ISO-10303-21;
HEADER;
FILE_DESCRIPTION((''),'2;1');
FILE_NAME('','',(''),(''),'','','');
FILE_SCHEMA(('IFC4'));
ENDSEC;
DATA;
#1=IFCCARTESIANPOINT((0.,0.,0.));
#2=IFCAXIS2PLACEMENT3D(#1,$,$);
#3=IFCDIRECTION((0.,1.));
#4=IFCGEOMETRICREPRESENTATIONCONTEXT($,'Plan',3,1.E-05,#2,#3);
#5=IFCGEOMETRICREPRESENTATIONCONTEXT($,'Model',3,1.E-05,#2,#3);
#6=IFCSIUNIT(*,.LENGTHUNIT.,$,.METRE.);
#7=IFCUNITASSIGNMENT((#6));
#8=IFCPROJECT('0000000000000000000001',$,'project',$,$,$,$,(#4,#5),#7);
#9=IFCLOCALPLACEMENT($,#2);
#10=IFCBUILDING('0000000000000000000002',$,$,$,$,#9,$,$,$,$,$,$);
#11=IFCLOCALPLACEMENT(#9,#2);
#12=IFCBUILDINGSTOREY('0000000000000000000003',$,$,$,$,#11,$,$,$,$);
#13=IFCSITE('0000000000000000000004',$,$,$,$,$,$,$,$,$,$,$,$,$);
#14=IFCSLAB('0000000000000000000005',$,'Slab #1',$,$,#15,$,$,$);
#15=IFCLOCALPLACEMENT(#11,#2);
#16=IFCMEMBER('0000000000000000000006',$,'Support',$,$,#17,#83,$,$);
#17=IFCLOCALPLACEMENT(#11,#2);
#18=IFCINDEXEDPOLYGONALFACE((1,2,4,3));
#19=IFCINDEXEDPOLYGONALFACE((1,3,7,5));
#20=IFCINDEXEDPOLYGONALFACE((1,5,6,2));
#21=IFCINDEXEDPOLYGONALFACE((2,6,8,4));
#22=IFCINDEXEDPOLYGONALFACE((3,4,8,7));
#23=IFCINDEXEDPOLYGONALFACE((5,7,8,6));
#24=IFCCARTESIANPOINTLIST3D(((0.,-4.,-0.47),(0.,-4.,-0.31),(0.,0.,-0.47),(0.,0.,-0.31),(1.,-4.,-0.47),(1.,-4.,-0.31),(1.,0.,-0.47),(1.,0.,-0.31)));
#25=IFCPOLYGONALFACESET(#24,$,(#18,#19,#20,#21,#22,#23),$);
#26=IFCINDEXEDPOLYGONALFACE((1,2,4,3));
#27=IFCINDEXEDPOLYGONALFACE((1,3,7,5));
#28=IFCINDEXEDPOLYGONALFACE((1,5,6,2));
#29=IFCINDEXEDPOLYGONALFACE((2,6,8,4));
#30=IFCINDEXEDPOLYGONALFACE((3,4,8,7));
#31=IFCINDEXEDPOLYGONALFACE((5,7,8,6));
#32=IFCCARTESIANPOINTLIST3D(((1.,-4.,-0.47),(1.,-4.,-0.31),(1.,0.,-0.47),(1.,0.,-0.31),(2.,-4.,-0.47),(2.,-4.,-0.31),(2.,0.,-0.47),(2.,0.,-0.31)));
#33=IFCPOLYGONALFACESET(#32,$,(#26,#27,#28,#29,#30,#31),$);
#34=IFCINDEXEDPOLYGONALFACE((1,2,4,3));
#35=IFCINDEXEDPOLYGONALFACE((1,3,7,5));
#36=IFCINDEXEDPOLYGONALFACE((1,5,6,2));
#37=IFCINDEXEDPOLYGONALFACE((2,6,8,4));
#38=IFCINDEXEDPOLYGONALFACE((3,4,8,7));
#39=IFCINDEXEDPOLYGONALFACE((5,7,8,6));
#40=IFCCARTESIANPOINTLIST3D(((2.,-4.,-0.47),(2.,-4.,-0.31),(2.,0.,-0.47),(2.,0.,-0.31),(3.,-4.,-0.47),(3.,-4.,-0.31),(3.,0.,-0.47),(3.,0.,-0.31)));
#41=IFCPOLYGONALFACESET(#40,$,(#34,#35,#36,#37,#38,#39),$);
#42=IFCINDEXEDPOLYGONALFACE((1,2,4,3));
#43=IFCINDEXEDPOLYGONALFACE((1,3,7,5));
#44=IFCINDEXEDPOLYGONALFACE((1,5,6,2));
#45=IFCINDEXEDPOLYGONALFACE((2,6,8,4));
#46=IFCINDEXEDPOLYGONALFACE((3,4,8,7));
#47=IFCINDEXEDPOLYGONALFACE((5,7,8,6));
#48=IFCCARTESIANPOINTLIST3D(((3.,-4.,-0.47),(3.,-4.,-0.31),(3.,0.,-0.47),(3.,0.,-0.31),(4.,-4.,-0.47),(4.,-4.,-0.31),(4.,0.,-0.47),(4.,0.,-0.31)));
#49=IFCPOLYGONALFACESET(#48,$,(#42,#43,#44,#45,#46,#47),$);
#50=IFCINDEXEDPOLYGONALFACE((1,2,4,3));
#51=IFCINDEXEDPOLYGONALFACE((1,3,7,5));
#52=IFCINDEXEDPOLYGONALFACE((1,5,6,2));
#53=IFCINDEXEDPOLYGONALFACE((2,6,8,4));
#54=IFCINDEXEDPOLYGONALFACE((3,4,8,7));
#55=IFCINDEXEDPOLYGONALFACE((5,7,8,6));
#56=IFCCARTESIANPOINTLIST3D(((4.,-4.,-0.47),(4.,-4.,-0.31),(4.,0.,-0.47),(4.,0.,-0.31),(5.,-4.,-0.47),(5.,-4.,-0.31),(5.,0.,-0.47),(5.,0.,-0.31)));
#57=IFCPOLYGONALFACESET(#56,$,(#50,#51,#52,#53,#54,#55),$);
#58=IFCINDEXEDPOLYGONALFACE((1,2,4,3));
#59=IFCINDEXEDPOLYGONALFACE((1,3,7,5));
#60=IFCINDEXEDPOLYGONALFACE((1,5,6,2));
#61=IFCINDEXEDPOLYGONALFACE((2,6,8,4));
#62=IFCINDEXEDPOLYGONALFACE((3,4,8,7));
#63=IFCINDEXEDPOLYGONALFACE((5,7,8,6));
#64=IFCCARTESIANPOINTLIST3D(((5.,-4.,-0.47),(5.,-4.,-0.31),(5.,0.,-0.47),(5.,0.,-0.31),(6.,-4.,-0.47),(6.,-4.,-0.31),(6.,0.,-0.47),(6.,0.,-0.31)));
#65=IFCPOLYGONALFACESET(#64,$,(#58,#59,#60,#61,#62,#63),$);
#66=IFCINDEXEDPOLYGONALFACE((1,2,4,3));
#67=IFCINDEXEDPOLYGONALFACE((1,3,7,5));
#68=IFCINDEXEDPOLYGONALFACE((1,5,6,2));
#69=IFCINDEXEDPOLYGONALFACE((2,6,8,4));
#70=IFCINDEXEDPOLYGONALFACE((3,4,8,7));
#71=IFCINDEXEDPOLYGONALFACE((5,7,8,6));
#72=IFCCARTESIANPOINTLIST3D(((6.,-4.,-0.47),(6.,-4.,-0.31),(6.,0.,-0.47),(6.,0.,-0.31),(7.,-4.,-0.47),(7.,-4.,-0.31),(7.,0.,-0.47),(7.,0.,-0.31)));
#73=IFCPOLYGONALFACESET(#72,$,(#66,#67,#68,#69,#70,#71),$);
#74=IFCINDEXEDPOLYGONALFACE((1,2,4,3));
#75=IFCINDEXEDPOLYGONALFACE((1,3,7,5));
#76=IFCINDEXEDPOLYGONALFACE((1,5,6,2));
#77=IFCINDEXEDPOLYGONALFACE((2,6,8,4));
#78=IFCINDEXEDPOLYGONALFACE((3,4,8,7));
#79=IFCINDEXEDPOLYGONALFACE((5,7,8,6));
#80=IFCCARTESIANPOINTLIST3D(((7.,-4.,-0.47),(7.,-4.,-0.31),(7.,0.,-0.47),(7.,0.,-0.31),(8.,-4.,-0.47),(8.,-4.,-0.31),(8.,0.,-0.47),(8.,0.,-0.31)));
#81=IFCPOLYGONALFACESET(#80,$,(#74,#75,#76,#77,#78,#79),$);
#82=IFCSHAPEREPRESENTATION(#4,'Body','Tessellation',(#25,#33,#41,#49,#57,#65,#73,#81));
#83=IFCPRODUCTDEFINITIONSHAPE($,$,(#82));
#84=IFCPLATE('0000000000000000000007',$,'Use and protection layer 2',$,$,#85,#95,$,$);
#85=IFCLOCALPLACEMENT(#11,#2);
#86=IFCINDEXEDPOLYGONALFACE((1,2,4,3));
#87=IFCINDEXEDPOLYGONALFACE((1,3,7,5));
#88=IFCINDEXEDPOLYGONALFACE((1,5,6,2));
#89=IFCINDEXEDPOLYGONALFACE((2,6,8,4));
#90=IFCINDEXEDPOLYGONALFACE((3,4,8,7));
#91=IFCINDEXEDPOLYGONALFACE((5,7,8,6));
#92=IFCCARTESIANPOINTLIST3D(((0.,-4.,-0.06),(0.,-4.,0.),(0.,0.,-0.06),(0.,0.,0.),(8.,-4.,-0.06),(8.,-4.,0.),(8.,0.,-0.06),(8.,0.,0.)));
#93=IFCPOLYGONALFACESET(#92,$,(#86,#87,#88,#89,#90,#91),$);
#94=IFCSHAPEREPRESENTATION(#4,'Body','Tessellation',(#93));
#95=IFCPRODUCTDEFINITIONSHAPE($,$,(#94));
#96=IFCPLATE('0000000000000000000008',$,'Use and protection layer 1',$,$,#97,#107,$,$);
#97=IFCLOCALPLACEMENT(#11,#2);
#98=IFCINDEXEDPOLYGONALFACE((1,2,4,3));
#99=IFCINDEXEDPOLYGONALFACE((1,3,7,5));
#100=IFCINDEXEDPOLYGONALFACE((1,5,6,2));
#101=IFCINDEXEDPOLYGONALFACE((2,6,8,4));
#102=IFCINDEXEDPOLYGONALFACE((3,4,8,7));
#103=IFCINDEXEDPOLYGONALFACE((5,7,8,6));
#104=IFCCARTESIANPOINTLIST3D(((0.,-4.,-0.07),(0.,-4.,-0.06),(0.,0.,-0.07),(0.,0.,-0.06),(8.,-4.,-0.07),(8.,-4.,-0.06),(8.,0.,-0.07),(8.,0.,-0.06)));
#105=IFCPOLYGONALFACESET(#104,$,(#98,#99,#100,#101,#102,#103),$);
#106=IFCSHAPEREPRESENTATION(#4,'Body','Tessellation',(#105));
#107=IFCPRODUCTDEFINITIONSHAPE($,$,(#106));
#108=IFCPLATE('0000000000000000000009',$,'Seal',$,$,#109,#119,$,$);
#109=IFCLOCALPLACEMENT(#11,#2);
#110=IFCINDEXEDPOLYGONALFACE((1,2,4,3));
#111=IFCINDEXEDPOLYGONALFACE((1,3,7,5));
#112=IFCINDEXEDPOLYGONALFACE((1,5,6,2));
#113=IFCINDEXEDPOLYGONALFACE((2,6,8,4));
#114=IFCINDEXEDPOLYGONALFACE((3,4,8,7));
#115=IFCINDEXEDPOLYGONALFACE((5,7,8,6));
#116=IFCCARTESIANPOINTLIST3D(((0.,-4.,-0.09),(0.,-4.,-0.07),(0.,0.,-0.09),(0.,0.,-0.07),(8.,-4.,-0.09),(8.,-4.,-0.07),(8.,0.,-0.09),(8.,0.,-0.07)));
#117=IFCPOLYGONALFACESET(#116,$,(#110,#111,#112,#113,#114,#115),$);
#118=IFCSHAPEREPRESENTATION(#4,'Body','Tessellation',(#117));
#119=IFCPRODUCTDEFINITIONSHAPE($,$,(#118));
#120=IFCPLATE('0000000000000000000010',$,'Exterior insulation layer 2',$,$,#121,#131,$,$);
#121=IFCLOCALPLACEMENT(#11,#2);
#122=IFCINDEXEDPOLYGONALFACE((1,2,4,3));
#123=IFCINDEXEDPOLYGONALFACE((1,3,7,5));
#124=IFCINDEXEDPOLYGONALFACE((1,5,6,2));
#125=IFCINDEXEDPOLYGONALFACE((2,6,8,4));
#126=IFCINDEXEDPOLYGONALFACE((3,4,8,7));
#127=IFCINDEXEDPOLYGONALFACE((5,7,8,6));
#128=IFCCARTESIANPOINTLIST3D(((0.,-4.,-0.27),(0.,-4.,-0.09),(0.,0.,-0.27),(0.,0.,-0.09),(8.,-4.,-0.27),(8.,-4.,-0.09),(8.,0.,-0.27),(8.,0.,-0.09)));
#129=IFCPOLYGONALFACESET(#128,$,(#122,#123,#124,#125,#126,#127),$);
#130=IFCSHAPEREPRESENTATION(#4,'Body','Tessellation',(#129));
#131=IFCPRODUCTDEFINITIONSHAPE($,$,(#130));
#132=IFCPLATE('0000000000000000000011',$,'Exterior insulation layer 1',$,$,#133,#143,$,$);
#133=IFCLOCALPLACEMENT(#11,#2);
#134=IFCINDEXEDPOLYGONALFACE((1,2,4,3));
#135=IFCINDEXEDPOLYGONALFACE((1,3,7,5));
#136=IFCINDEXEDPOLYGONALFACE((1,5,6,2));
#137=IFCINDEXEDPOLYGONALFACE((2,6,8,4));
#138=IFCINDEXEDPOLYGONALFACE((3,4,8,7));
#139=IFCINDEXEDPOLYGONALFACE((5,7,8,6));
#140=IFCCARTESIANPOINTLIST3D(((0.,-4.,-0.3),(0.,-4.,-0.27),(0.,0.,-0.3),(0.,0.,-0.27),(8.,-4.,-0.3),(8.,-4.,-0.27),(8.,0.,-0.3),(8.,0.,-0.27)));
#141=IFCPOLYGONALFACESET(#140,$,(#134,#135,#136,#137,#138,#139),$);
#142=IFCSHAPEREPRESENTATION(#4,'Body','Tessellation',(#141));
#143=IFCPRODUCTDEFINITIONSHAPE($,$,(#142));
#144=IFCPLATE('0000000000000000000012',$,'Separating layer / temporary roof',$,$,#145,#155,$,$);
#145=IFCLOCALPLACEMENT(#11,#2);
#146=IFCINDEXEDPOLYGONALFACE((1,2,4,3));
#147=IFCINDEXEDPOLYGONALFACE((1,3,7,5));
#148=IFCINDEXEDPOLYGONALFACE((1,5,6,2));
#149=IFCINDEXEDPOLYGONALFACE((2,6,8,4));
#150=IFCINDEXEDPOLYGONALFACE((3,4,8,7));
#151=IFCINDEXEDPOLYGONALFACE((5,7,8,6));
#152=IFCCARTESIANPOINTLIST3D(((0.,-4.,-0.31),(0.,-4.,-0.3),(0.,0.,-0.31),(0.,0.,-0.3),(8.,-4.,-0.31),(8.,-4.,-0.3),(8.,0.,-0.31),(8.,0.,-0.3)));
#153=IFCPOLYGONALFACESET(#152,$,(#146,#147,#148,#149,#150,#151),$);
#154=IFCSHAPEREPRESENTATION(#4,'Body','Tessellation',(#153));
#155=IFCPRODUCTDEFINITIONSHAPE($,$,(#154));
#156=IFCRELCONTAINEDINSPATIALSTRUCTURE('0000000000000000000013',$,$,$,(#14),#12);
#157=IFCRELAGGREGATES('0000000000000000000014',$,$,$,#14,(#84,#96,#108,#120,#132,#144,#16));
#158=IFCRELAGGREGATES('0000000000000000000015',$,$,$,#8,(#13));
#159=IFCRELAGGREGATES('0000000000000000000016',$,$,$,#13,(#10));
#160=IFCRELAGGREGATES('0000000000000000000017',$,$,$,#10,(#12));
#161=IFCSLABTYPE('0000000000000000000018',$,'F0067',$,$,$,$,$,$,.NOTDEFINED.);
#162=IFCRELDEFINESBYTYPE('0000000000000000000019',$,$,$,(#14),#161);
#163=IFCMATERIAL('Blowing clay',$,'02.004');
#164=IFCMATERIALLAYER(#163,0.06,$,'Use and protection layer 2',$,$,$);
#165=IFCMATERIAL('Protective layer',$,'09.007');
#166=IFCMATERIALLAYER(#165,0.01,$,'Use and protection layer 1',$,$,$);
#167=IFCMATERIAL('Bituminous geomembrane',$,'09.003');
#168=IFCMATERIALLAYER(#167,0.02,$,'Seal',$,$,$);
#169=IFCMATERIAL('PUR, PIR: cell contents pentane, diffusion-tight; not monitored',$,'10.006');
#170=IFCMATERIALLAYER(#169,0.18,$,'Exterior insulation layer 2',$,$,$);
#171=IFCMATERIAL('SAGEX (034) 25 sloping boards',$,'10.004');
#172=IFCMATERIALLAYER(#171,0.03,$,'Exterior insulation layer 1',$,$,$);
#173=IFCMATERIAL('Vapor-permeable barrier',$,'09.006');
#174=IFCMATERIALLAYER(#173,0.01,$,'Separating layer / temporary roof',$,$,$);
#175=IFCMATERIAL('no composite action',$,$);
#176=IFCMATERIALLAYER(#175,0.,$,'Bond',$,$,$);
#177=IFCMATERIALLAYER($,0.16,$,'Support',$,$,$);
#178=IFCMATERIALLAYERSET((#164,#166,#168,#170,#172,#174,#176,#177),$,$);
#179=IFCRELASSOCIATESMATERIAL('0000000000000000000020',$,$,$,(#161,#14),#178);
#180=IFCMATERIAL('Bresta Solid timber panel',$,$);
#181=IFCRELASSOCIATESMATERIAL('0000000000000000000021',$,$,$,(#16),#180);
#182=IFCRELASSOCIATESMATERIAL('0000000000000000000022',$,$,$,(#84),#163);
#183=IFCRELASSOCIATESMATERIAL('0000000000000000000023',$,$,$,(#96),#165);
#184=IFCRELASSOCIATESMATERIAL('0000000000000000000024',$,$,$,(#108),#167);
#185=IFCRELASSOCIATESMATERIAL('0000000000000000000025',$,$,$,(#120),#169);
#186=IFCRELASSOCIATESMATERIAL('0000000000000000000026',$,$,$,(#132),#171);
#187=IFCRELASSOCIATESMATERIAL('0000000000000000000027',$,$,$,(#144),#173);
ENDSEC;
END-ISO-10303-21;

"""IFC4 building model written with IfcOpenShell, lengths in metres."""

from ifc_helpers import new_model, si_unit, direction, frame, frame_2d, origin, origin_with_axes, place, context, project, spatial, rectangle, extrude, material, layer, layer_set, type_object, element, aggregate, save


model = new_model("IFC4")

# Units and contexts
plan_context = context("Plan", 3, precision=1e-05, world=origin(), true_north=direction((0.0, 1.0)))
model_context = context("Model", 3, precision=1e-05, world=origin(), true_north=direction((0.0, 1.0)))
ifc_project = project(units=[si_unit("LENGTHUNIT", "METRE")], contexts=[plan_context, model_context])

# Site, building, storey
site = spatial("IfcSite", under=ifc_project)
building_placement = place(None, origin())
building = spatial("IfcBuilding", under=site, at=building_placement)
storey_placement = place(building_placement, origin())
storey = spatial("IfcBuildingStorey", under=building, at=storey_placement)

# Slab, member, plates
ifc_material_1 = material(Name="Blowing clay", Category="02.004")
ifc_layer_1 = layer(ifc_material_1, 0.06, Name="Use and protection layer 2")
ifc_material_2 = material(Name="Protective layer", Category="09.007")
ifc_layer_2 = layer(ifc_material_2, 0.01, Name="Use and protection layer 1")
ifc_material_3 = material(Name="Bituminous geomembrane", Category="09.003")
ifc_layer_3 = layer(ifc_material_3, 0.02, Name="Seal")
ifc_material_4 = material(Name="PUR, PIR: cell contents pentane, diffusion-tight; not monitored", Category="10.006")
ifc_layer_4 = layer(ifc_material_4, 0.18, Name="Exterior insulation layer 2")
ifc_material_5 = material(Name="SAGEX (034) 25 sloping boards", Category="10.004")
ifc_layer_5 = layer(ifc_material_5, 0.03, Name="Exterior insulation layer 1")
ifc_material_6 = material(Name="Vapor-permeable barrier", Category="09.006")
ifc_layer_6 = layer(ifc_material_6, 0.01, Name="Separating layer / temporary roof")
ifc_material_7 = material(Name="no composite action")
ifc_layer_7 = layer(ifc_material_7, 0.0, Name="Bond")
ifc_layer_8 = layer(None, 0.16, Name="Support")
ifc_layer_set = layer_set([ifc_layer_1, ifc_layer_2, ifc_layer_3, ifc_layer_4, ifc_layer_5, ifc_layer_6, ifc_layer_7, ifc_layer_8])
slab_type = type_object("IfcSlabType", Name="F0067", PredefinedType="NOTDEFINED", material=ifc_layer_set)
slab_placement = place(None, frame((0.0, 0.0, 0.0), z_axis=(0.0, 0.0, -1.0), x_axis=(1.0, 0.0, 0.0)))
slab = element("IfcSlab", 1, at=slab_placement, inside=storey, type_object=slab_type, material=ifc_layer_set, Name="Slab #1")
ifc_material_8 = material(Name="Bresta Solid timber panel")
member_placement = place(slab_placement, origin())
member = element("IfcMember", 2, at=member_placement, material=ifc_material_8, Name="Support", context=plan_context, shape_type="SweptSolid", body=[
    extrude(rectangle(XDim=1.0, YDim=0.16, at=frame_2d((0.5, 0.08), x_axis=(1.0, 0.0))), frame((0.0, 4.0, 0.31), z_axis=(0.0, -1.0, 0.0), x_axis=(1.0, 0.0, 0.0)), (0.0, 0.0, 1.0), 4.0),
    extrude(rectangle(XDim=1.0, YDim=0.16, at=frame_2d((0.5, 0.08), x_axis=(1.0, 0.0))), frame((1.0, 4.0, 0.31), z_axis=(0.0, -1.0, 0.0), x_axis=(1.0, 0.0, 0.0)), (0.0, 0.0, 1.0), 4.0),
    extrude(rectangle(XDim=1.0, YDim=0.16, at=frame_2d((0.5, 0.08), x_axis=(1.0, 0.0))), frame((2.0, 4.0, 0.31), z_axis=(0.0, -1.0, 0.0), x_axis=(1.0, 0.0, 0.0)), (0.0, 0.0, 1.0), 4.0),
    extrude(rectangle(XDim=1.0, YDim=0.16, at=frame_2d((0.5, 0.08), x_axis=(1.0, 0.0))), frame((3.0, 4.0, 0.31), z_axis=(0.0, -1.0, 0.0), x_axis=(1.0, 0.0, 0.0)), (0.0, 0.0, 1.0), 4.0),
    extrude(rectangle(XDim=1.0, YDim=0.16, at=frame_2d((0.5, 0.08), x_axis=(1.0, 0.0))), frame((4.0, 4.0, 0.31), z_axis=(0.0, -1.0, 0.0), x_axis=(1.0, 0.0, 0.0)), (0.0, 0.0, 1.0), 4.0),
    extrude(rectangle(XDim=1.0, YDim=0.16, at=frame_2d((0.5, 0.08), x_axis=(1.0, 0.0))), frame((5.0, 4.0, 0.31), z_axis=(0.0, -1.0, 0.0), x_axis=(1.0, 0.0, 0.0)), (0.0, 0.0, 1.0), 4.0),
    extrude(rectangle(XDim=1.0, YDim=0.16, at=frame_2d((0.5, 0.08), x_axis=(1.0, 0.0))), frame((6.0, 4.0, 0.31), z_axis=(0.0, -1.0, 0.0), x_axis=(1.0, 0.0, 0.0)), (0.0, 0.0, 1.0), 4.0),
    extrude(rectangle(XDim=1.0, YDim=0.16, at=frame_2d((0.5, 0.08), x_axis=(1.0, 0.0))), frame((7.0, 4.0, 0.31), z_axis=(0.0, -1.0, 0.0), x_axis=(1.0, 0.0, 0.0)), (0.0, 0.0, 1.0), 4.0),
])
plate_1_placement = place(slab_placement, origin())
plate_1 = element("IfcPlate", 3, at=plate_1_placement, material=ifc_material_1, Name="Use and protection layer 2", context=plan_context, shape_type="SweptSolid", body=[
    extrude(rectangle(XDim=8.0, YDim=4.0, at=frame_2d((4.0, 2.0), x_axis=(1.0, 0.0))), origin_with_axes(), (0.0, 0.0, 1.0), 0.06),
])
plate_2_placement = place(slab_placement, origin())
plate_2 = element("IfcPlate", 4, at=plate_2_placement, material=ifc_material_2, Name="Use and protection layer 1", context=plan_context, shape_type="SweptSolid", body=[
    extrude(rectangle(XDim=8.0, YDim=4.0, at=frame_2d((4.0, 2.0), x_axis=(1.0, 0.0))), frame((0.0, 0.0, 0.06), z_axis=(0.0, 0.0, 1.0), x_axis=(1.0, 0.0, 0.0)), (0.0, 0.0, 1.0), 0.01),
])
plate_3_placement = place(slab_placement, origin())
plate_3 = element("IfcPlate", 5, at=plate_3_placement, material=ifc_material_3, Name="Seal", context=plan_context, shape_type="SweptSolid", body=[
    extrude(rectangle(XDim=8.0, YDim=4.0, at=frame_2d((4.0, 2.0), x_axis=(1.0, 0.0))), frame((0.0, 0.0, 0.07), z_axis=(0.0, 0.0, 1.0), x_axis=(1.0, 0.0, 0.0)), (0.0, 0.0, 1.0), 0.02),
])
plate_4_placement = place(slab_placement, origin())
plate_4 = element("IfcPlate", 6, at=plate_4_placement, material=ifc_material_4, Name="Exterior insulation layer 2", context=plan_context, shape_type="SweptSolid", body=[
    extrude(rectangle(XDim=8.0, YDim=4.0, at=frame_2d((4.0, 2.0), x_axis=(1.0, 0.0))), frame((0.0, 0.0, 0.09), z_axis=(0.0, 0.0, 1.0), x_axis=(1.0, 0.0, 0.0)), (0.0, 0.0, 1.0), 0.18),
])
plate_5_placement = place(slab_placement, origin())
plate_5 = element("IfcPlate", 7, at=plate_5_placement, material=ifc_material_5, Name="Exterior insulation layer 1", context=plan_context, shape_type="SweptSolid", body=[
    extrude(rectangle(XDim=8.0, YDim=4.0, at=frame_2d((4.0, 2.0), x_axis=(1.0, 0.0))), frame((0.0, 0.0, 0.27), z_axis=(0.0, 0.0, 1.0), x_axis=(1.0, 0.0, 0.0)), (0.0, 0.0, 1.0), 0.03),
])
plate_6_placement = place(slab_placement, origin())
plate_6 = element("IfcPlate", 8, at=plate_6_placement, material=ifc_material_6, Name="Separating layer / temporary roof", context=plan_context, shape_type="SweptSolid", body=[
    extrude(rectangle(XDim=8.0, YDim=4.0, at=frame_2d((4.0, 2.0), x_axis=(1.0, 0.0))), frame((0.0, 0.0, 0.3), z_axis=(0.0, 0.0, 1.0), x_axis=(1.0, 0.0, 0.0)), (0.0, 0.0, 1.0), 0.01),
])
aggregate(slab, [plate_1, plate_2, plate_3, plate_4, plate_5, plate_6, member])

save(model, "model.ifc")
